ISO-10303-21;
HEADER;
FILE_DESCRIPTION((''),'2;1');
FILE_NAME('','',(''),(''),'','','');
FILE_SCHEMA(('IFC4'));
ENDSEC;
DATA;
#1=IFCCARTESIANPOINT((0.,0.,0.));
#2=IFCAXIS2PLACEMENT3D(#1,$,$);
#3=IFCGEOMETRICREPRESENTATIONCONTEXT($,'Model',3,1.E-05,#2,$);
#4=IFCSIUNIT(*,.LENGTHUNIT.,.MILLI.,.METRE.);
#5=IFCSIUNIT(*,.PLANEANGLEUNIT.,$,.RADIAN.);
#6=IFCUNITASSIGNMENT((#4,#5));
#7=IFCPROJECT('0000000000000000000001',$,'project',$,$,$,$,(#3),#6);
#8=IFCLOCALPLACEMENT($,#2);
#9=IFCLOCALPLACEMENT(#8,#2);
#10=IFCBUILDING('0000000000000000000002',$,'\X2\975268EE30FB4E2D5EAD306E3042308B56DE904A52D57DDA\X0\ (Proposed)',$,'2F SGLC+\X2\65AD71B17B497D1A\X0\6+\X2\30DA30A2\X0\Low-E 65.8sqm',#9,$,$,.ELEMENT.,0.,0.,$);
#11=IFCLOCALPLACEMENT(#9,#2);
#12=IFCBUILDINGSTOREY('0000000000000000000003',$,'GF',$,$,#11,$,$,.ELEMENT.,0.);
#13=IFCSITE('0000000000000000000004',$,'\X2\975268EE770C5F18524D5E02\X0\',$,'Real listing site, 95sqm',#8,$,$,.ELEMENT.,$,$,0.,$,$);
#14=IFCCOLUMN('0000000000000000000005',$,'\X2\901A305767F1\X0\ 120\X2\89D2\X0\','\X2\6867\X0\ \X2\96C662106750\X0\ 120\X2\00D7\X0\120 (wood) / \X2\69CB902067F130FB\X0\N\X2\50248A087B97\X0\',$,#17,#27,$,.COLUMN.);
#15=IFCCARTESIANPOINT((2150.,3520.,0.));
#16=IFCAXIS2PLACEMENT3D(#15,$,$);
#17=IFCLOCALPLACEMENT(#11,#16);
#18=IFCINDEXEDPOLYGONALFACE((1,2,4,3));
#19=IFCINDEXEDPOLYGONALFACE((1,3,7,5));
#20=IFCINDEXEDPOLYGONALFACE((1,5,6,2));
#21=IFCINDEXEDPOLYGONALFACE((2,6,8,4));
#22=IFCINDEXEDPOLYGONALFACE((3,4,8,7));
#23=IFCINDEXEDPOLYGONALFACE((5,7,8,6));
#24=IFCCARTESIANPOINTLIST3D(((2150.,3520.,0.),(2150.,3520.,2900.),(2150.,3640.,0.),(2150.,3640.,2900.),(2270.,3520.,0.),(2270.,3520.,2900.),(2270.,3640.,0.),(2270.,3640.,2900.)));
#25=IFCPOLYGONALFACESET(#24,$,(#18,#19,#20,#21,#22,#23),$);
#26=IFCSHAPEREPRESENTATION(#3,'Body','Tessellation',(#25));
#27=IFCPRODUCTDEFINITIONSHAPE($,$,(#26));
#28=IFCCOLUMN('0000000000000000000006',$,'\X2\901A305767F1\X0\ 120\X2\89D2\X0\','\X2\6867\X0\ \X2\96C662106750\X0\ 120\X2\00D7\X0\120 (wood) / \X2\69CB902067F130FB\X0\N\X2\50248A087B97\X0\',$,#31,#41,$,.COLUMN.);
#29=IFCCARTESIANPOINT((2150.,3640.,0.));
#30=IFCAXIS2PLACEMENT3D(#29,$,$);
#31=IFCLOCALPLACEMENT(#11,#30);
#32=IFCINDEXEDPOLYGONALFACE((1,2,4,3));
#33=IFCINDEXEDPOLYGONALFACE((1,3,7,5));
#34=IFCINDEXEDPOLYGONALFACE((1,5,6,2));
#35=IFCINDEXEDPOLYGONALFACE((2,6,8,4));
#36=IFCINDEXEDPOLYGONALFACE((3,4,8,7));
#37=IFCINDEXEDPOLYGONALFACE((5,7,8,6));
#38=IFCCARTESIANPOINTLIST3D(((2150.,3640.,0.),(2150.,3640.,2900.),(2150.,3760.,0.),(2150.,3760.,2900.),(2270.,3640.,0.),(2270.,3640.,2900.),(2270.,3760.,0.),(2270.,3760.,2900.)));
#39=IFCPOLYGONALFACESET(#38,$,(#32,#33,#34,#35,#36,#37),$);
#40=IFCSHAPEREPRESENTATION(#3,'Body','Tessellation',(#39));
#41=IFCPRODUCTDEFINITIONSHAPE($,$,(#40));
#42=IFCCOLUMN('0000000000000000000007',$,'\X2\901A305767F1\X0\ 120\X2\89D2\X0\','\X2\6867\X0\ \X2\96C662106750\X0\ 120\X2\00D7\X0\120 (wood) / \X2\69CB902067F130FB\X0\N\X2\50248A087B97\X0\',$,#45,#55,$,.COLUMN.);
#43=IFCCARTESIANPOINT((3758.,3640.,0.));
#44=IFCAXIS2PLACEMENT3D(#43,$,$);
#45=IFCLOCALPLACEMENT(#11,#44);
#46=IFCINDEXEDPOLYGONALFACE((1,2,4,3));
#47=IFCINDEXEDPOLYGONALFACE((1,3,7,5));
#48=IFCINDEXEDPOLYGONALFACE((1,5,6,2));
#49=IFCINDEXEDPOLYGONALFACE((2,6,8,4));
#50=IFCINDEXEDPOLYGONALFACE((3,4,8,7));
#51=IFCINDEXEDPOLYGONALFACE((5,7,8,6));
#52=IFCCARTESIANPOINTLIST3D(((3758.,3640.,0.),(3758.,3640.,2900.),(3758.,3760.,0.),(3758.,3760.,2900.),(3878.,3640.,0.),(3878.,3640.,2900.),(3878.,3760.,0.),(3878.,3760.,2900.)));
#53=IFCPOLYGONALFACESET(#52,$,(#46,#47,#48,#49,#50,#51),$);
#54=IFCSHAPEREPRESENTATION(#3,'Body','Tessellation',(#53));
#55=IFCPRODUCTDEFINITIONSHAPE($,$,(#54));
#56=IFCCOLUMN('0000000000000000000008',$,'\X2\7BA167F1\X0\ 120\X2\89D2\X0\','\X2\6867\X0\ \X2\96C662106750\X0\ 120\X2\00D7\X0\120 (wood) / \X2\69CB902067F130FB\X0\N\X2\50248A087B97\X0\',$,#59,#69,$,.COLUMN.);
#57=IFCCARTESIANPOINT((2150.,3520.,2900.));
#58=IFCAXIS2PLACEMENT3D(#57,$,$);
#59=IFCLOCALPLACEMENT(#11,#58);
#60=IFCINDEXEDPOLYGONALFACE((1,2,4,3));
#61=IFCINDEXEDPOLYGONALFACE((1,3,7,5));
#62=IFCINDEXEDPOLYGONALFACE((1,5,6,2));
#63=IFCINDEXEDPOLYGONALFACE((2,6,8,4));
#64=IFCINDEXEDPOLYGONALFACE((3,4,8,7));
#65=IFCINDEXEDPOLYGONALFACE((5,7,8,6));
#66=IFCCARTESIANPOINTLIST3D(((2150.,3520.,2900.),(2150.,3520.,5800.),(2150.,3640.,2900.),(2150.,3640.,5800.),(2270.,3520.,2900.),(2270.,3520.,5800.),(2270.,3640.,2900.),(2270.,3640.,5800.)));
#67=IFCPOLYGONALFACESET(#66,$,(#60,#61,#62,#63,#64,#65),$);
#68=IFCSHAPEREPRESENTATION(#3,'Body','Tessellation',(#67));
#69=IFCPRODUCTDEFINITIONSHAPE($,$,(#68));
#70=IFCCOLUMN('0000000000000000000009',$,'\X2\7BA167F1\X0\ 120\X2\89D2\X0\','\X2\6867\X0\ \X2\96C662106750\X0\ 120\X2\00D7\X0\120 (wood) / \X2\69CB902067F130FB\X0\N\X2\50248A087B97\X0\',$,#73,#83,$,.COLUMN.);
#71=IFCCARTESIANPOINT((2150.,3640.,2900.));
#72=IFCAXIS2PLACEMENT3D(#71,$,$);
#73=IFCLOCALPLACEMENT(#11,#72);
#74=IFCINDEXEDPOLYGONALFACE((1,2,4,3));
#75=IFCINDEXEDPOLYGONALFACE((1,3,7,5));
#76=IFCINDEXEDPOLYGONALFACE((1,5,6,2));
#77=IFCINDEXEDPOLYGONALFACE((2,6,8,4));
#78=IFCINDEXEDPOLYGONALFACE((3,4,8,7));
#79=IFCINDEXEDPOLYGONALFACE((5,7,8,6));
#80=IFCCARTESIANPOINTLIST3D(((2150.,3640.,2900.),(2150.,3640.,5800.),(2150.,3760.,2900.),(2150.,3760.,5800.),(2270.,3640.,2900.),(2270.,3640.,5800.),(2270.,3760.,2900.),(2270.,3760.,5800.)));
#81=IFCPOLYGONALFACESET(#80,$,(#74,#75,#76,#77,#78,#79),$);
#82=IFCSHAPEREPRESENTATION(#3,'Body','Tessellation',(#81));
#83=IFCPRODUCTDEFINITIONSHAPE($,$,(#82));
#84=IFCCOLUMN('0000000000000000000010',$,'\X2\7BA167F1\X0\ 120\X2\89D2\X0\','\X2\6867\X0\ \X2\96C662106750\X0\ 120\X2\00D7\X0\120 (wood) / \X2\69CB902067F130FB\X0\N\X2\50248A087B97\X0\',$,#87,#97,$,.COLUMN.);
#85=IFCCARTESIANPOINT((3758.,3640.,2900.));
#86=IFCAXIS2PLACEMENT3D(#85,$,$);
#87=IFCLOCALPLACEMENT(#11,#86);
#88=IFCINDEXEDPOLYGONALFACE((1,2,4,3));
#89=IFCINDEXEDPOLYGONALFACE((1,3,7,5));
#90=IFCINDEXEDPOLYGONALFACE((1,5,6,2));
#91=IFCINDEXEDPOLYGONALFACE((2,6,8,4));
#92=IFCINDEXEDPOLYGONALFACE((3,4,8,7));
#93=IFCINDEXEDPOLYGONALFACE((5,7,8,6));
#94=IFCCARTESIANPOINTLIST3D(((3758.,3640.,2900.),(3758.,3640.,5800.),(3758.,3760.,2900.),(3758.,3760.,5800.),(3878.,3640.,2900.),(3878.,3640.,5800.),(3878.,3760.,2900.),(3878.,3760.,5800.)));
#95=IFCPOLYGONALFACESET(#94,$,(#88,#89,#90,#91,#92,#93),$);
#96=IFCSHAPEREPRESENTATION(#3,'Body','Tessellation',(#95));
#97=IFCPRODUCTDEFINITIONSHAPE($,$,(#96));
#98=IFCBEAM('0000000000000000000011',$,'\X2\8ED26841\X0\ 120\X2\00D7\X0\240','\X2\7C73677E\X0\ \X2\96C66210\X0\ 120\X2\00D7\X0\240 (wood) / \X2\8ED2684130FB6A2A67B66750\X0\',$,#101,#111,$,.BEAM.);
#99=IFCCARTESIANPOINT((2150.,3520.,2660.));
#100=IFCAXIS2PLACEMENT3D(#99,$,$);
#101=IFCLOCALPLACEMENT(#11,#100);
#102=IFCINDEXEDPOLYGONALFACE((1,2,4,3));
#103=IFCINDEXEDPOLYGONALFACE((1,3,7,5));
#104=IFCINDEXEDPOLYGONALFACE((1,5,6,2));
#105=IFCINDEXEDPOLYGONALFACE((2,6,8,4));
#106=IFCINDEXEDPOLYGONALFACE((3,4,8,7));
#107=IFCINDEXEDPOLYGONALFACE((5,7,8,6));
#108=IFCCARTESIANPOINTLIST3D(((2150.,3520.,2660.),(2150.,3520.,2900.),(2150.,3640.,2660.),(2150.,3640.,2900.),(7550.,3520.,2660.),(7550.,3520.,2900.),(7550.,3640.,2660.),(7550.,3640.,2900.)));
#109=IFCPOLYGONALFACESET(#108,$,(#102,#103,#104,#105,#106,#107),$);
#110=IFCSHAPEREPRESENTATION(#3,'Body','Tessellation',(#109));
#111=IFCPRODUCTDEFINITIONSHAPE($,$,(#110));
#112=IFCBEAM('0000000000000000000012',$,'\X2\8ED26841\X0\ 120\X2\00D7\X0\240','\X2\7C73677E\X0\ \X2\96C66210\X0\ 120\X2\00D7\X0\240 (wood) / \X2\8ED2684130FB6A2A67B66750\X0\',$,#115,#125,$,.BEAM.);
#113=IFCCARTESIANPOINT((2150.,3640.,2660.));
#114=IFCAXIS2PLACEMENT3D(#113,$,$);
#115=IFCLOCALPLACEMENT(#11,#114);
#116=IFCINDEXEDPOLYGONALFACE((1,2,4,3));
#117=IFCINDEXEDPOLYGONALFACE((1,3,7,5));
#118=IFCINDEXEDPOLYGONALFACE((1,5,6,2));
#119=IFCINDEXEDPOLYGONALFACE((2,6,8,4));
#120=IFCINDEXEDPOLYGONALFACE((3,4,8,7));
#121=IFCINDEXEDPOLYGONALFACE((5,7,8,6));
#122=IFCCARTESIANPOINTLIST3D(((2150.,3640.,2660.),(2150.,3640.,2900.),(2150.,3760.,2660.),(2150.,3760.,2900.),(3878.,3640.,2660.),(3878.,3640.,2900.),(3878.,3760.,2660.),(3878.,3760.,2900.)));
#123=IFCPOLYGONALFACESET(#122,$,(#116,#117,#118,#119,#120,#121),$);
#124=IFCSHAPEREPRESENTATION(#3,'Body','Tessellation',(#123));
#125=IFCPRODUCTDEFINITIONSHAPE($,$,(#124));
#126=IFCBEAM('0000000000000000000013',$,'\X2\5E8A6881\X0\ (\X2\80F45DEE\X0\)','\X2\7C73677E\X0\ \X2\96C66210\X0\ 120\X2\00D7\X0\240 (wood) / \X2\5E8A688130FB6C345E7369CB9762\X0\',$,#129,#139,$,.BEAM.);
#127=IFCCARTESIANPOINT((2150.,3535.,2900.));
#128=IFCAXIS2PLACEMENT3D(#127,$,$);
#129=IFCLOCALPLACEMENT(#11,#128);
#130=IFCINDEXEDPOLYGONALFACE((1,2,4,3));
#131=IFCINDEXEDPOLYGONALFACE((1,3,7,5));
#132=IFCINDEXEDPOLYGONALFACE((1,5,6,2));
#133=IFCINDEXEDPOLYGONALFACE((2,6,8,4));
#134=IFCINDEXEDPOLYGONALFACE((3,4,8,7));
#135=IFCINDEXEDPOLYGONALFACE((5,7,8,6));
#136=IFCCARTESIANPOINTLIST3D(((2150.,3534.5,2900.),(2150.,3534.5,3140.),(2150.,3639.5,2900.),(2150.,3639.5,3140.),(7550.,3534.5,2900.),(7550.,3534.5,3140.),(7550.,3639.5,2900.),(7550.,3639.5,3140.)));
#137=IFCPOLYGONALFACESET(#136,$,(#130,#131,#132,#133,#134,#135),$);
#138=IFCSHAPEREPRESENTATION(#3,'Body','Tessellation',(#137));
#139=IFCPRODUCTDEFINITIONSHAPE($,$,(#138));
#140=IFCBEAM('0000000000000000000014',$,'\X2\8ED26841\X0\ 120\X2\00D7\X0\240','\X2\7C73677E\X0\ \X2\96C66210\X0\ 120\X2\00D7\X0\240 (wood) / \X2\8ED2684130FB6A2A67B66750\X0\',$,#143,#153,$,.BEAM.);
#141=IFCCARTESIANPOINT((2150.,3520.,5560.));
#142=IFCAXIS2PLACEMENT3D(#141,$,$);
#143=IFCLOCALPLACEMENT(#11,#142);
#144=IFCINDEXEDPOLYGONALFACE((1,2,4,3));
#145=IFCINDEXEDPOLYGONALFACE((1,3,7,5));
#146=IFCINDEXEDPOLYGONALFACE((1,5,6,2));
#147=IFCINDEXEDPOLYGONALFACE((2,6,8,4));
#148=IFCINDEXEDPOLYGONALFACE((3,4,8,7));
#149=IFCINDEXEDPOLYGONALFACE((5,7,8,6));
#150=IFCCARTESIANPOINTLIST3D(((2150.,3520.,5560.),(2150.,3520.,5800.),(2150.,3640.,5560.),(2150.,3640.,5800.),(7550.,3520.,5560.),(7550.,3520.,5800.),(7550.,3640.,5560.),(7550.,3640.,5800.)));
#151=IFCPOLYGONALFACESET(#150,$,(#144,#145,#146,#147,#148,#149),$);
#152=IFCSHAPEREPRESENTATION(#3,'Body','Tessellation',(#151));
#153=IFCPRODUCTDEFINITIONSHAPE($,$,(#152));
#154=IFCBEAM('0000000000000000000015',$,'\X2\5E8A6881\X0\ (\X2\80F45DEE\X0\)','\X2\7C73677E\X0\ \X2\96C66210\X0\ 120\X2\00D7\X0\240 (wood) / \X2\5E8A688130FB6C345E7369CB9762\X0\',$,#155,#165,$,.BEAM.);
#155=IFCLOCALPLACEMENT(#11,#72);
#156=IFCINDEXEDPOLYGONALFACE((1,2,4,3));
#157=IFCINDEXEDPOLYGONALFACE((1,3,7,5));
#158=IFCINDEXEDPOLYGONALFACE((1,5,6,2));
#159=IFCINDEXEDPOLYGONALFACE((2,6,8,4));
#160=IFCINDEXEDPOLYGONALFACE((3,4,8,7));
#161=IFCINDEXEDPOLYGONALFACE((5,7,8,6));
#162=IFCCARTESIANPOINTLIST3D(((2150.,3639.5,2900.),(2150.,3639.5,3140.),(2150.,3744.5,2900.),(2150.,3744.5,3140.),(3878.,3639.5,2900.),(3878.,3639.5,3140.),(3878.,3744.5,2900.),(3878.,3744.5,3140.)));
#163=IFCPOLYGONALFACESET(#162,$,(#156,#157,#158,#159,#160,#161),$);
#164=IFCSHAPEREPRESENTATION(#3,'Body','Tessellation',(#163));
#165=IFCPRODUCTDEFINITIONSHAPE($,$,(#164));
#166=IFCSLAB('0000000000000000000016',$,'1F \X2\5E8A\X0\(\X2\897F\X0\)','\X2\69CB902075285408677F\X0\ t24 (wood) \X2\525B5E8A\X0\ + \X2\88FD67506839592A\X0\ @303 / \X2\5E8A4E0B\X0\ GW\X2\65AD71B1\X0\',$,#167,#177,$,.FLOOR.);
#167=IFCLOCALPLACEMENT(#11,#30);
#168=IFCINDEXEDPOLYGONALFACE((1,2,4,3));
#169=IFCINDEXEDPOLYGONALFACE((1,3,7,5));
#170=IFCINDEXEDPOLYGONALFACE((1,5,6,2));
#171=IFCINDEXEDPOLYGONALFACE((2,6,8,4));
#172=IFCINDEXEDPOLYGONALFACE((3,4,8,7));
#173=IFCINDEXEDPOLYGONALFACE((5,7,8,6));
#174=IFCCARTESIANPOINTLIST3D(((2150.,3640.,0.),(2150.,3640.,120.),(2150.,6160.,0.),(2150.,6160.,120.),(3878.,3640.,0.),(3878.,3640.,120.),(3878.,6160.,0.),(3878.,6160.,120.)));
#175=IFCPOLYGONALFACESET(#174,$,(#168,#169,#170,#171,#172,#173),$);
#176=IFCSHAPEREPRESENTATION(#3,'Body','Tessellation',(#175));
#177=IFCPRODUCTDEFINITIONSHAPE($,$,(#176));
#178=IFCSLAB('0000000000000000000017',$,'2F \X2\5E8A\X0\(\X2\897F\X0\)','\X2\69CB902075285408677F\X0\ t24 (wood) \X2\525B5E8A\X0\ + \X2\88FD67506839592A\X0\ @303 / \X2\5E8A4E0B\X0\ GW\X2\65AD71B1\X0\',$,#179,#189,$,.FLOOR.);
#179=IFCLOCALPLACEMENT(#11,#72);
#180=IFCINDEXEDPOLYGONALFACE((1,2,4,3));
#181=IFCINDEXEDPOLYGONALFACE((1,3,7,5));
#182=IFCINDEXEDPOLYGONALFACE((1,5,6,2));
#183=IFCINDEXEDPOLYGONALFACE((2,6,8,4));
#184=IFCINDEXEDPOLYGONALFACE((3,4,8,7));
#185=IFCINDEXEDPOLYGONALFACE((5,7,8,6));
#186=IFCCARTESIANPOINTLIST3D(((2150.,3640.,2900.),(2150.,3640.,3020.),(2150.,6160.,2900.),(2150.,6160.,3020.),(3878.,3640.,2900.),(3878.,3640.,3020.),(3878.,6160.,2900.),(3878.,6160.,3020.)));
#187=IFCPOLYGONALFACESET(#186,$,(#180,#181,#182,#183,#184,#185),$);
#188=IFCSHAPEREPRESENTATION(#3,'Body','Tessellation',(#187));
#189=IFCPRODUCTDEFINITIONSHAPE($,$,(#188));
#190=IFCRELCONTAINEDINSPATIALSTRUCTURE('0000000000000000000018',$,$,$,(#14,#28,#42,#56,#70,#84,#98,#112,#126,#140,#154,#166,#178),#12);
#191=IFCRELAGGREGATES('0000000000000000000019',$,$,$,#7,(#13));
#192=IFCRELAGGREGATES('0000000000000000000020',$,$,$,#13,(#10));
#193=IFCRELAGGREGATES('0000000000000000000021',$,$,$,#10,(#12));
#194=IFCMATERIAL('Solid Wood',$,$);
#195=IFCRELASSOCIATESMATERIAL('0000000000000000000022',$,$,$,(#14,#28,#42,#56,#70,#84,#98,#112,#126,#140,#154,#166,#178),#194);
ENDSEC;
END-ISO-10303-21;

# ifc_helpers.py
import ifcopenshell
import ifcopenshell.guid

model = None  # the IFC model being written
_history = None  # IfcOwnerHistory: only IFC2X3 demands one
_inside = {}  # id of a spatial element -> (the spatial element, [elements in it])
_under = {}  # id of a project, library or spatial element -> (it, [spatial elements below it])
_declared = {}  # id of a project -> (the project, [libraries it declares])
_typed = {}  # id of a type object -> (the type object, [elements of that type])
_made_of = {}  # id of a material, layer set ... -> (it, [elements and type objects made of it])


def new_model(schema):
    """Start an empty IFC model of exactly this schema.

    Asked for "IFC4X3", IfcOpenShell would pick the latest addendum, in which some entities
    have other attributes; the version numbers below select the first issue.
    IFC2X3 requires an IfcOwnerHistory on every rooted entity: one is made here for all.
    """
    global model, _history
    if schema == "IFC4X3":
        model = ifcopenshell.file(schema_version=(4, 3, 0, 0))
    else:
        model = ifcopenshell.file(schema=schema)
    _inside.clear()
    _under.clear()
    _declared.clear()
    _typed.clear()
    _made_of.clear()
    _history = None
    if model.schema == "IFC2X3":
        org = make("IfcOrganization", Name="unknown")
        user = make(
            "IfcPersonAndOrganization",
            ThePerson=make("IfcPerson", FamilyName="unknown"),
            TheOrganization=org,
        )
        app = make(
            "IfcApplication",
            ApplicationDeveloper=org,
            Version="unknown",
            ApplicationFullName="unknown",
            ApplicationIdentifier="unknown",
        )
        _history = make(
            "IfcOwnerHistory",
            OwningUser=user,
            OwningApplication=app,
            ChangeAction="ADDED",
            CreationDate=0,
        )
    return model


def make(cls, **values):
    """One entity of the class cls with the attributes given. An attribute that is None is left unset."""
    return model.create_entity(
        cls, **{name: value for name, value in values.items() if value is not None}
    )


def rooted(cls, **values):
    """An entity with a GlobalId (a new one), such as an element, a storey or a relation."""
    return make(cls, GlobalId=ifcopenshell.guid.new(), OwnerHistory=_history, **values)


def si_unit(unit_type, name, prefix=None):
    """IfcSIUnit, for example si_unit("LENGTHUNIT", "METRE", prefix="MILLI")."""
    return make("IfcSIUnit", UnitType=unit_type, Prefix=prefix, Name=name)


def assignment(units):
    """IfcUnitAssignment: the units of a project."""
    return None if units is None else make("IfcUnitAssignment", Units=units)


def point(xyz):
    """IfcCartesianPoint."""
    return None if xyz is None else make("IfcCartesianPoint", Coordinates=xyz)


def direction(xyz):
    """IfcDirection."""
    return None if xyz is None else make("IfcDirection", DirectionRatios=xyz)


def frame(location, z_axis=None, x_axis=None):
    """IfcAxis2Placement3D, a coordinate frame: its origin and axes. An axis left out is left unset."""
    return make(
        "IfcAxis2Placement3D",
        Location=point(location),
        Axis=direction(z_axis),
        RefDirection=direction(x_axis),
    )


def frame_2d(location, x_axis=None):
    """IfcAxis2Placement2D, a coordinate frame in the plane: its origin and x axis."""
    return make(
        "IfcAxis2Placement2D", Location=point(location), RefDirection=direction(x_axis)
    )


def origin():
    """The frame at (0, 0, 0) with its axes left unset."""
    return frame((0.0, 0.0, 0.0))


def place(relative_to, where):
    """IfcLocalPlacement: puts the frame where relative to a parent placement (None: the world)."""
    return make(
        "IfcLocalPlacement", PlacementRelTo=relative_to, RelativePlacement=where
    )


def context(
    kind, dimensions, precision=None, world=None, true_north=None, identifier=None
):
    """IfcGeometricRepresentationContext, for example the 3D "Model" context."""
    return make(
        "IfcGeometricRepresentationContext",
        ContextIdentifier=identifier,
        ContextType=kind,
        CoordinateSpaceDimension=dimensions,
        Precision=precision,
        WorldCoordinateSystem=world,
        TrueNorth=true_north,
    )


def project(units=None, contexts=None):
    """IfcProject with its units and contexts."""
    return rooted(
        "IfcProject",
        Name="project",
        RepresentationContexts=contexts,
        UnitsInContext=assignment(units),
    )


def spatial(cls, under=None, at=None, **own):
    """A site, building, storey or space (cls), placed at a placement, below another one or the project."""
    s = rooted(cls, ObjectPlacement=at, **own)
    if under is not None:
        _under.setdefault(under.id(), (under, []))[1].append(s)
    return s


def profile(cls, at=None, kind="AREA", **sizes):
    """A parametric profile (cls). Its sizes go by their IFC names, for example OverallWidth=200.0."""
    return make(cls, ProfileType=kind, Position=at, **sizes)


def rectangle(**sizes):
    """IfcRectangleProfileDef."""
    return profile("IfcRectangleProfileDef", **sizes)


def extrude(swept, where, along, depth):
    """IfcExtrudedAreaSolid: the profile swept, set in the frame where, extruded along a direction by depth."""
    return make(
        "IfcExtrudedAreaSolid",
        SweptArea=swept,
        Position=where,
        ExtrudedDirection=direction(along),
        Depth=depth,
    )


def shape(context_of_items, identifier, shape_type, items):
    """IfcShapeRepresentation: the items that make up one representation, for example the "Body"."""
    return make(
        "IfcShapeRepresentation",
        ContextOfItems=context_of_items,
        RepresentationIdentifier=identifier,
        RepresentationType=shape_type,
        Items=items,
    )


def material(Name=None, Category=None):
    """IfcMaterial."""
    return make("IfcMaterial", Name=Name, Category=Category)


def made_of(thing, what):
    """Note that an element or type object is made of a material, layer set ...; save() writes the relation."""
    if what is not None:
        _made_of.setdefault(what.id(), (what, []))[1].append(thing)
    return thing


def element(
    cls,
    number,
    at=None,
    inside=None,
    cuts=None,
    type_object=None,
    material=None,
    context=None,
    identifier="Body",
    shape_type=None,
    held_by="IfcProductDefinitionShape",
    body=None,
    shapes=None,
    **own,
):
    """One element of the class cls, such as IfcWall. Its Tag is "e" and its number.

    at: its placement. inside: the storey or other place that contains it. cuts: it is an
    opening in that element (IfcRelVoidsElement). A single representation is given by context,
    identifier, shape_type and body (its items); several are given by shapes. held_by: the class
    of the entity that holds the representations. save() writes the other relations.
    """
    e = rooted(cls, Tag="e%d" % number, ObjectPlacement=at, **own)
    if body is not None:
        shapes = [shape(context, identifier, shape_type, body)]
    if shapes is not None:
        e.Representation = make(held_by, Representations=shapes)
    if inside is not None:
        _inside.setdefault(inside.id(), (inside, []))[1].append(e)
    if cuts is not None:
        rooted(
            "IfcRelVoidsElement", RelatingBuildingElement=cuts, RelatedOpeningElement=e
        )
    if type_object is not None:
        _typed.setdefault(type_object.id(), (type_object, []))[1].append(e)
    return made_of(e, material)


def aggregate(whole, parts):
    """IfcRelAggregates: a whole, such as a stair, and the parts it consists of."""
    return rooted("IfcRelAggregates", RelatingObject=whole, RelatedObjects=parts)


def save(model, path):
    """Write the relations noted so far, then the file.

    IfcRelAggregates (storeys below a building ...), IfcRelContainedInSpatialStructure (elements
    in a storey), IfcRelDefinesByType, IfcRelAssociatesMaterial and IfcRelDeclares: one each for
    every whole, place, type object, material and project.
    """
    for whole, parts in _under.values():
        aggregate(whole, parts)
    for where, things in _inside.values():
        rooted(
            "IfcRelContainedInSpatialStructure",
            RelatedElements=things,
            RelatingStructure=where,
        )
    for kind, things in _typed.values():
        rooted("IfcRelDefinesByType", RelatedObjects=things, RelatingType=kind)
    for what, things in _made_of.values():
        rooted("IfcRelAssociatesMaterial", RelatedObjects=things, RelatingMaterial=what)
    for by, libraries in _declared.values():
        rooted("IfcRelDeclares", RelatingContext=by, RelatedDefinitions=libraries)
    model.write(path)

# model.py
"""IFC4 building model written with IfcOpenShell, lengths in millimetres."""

from ifc_helpers import new_model, si_unit, frame, frame_2d, origin, place, context, project, spatial, rectangle, extrude, material, element, save


model = new_model("IFC4")

# Units and contexts
model_context = context("Model", 3, precision=1e-05, world=origin())
ifc_project = project(units=[si_unit("LENGTHUNIT", "METRE", prefix="MILLI"), si_unit("PLANEANGLEUNIT", "RADIAN")], contexts=[model_context])

# Site, building, storey
site_placement = place(None, origin())
site = spatial("IfcSite", under=ifc_project, at=site_placement, Name="青森県弘前市", ObjectType="Real listing site, 95sqm", CompositionType="ELEMENT", RefElevation=0.0)
building_placement = place(site_placement, origin())
building = spatial("IfcBuilding", under=site, at=building_placement, Name="青森・中庭のある回遊動線 (Proposed)", ObjectType="2F SGLC+断熱等級6+ペアLow-E 65.8sqm", CompositionType="ELEMENT", ElevationOfRefHeight=0.0, ElevationOfTerrain=0.0)
storey_placement = place(building_placement, origin())
storey = spatial("IfcBuildingStorey", under=building, at=storey_placement, Name="GF", CompositionType="ELEMENT", Elevation=0.0)

# Columns
ifc_material_1 = material(Name="Solid Wood")
column_1_placement = place(storey_placement, frame((2150.0, 3520.0, 0.0)))
element("IfcColumn", 1, at=column_1_placement, inside=storey, material=ifc_material_1, Name="通し柱 120角", Description="桧 集成材 120×120 (wood) / 構造柱・N値計算", PredefinedType="COLUMN", context=model_context, shape_type="SweptSolid", body=[
    extrude(rectangle(XDim=120.0, YDim=120.0, at=frame_2d((60.0, 60.0))), frame((2150.0, 3520.0, 0.0)), (0.0, 0.0, 1.0), 2900.0),
])
column_2_placement = place(storey_placement, frame((2150.0, 3640.0, 0.0)))
element("IfcColumn", 2, at=column_2_placement, inside=storey, material=ifc_material_1, Name="通し柱 120角", Description="桧 集成材 120×120 (wood) / 構造柱・N値計算", PredefinedType="COLUMN", context=model_context, shape_type="SweptSolid", body=[
    extrude(rectangle(XDim=120.0, YDim=120.0, at=frame_2d((60.0, 60.0))), frame((2150.0, 3640.0, 0.0)), (0.0, 0.0, 1.0), 2900.0),
])
column_3_placement = place(storey_placement, frame((3758.0, 3640.0, 0.0)))
element("IfcColumn", 3, at=column_3_placement, inside=storey, material=ifc_material_1, Name="通し柱 120角", Description="桧 集成材 120×120 (wood) / 構造柱・N値計算", PredefinedType="COLUMN", context=model_context, shape_type="SweptSolid", body=[
    extrude(rectangle(XDim=120.0, YDim=120.0, at=frame_2d((60.0, 60.0))), frame((3758.0, 3640.0, 0.0)), (0.0, 0.0, 1.0), 2900.0),
])
column_4_placement = place(storey_placement, frame((2150.0, 3520.0, 2900.0)))
element("IfcColumn", 4, at=column_4_placement, inside=storey, material=ifc_material_1, Name="管柱 120角", Description="桧 集成材 120×120 (wood) / 構造柱・N値計算", PredefinedType="COLUMN", context=model_context, shape_type="SweptSolid", body=[
    extrude(rectangle(XDim=120.0, YDim=120.0, at=frame_2d((60.0, 60.0))), frame((2150.0, 3520.0, 2900.0)), (0.0, 0.0, 1.0), 2900.0),
])
column_5_placement = place(storey_placement, frame((2150.0, 3640.0, 2900.0)))
element("IfcColumn", 5, at=column_5_placement, inside=storey, material=ifc_material_1, Name="管柱 120角", Description="桧 集成材 120×120 (wood) / 構造柱・N値計算", PredefinedType="COLUMN", context=model_context, shape_type="SweptSolid", body=[
    extrude(rectangle(XDim=120.0, YDim=120.0, at=frame_2d((60.0, 60.0))), frame((2150.0, 3640.0, 2900.0)), (0.0, 0.0, 1.0), 2900.0),
])
column_6_placement = place(storey_placement, frame((3758.0, 3640.0, 2900.0)))
element("IfcColumn", 6, at=column_6_placement, inside=storey, material=ifc_material_1, Name="管柱 120角", Description="桧 集成材 120×120 (wood) / 構造柱・N値計算", PredefinedType="COLUMN", context=model_context, shape_type="SweptSolid", body=[
    extrude(rectangle(XDim=120.0, YDim=120.0, at=frame_2d((60.0, 60.0))), frame((3758.0, 3640.0, 2900.0)), (0.0, 0.0, 1.0), 2900.0),
])

# Beams
beam_1_placement = place(storey_placement, frame((2150.0, 3520.0, 2660.0)))
element("IfcBeam", 7, at=beam_1_placement, inside=storey, material=ifc_material_1, Name="軒桁 120×240", Description="米松 集成 120×240 (wood) / 軒桁・横架材", PredefinedType="BEAM", context=model_context, shape_type="SweptSolid", body=[
    extrude(rectangle(XDim=5400.0, YDim=120.0, at=frame_2d((2700.0, 60.0))), frame((2150.0, 3520.0, 2660.0)), (0.0, 0.0, 1.0), 240.0),
])
beam_2_placement = place(storey_placement, frame((2150.0, 3640.0, 2660.0)))
element("IfcBeam", 8, at=beam_2_placement, inside=storey, material=ifc_material_1, Name="軒桁 120×240", Description="米松 集成 120×240 (wood) / 軒桁・横架材", PredefinedType="BEAM", context=model_context, shape_type="SweptSolid", body=[
    extrude(rectangle(XDim=1728.0, YDim=120.0, at=frame_2d((864.0, 60.0))), frame((2150.0, 3640.0, 2660.0)), (0.0, 0.0, 1.0), 240.0),
])
beam_3_placement = place(storey_placement, frame((2150.0, 3535.0, 2900.0)))
element("IfcBeam", 9, at=beam_3_placement, inside=storey, material=ifc_material_1, Name="床梁 (胴差)", Description="米松 集成 120×240 (wood) / 床梁・水平構面", PredefinedType="BEAM", context=model_context, shape_type="SweptSolid", body=[
    extrude(rectangle(XDim=5400.0, YDim=105.0, at=frame_2d((2700.0, 52.0))), frame((2150.0, 3535.0, 2900.0)), (0.0, 0.0, 1.0), 240.0),
])
beam_4_placement = place(storey_placement, frame((2150.0, 3520.0, 5560.0)))
element("IfcBeam", 10, at=beam_4_placement, inside=storey, material=ifc_material_1, Name="軒桁 120×240", Description="米松 集成 120×240 (wood) / 軒桁・横架材", PredefinedType="BEAM", context=model_context, shape_type="SweptSolid", body=[
    extrude(rectangle(XDim=5400.0, YDim=120.0, at=frame_2d((2700.0, 60.0))), frame((2150.0, 3520.0, 5560.0)), (0.0, 0.0, 1.0), 240.0),
])
beam_5_placement = place(storey_placement, frame((2150.0, 3640.0, 2900.0)))
element("IfcBeam", 11, at=beam_5_placement, inside=storey, material=ifc_material_1, Name="床梁 (胴差)", Description="米松 集成 120×240 (wood) / 床梁・水平構面", PredefinedType="BEAM", context=model_context, shape_type="SweptSolid", body=[
    extrude(rectangle(XDim=1728.0, YDim=105.0, at=frame_2d((864.0, 52.0))), frame((2150.0, 3640.0, 2900.0)), (0.0, 0.0, 1.0), 240.0),
])

# Slabs
slab_1_placement = place(storey_placement, frame((2150.0, 3640.0, 0.0)))
element("IfcSlab", 12, at=slab_1_placement, inside=storey, material=ifc_material_1, Name="1F 床(西)", Description="構造用合板 t24 (wood) 剛床 + 製材根太 @303 / 床下 GW断熱", PredefinedType="FLOOR", context=model_context, shape_type="SweptSolid", body=[
    extrude(rectangle(XDim=1728.0, YDim=2520.0, at=frame_2d((864.0, 1260.0))), frame((2150.0, 3640.0, 0.0)), (0.0, 0.0, 1.0), 120.0),
])
slab_2_placement = place(storey_placement, frame((2150.0, 3640.0, 2900.0)))
element("IfcSlab", 13, at=slab_2_placement, inside=storey, material=ifc_material_1, Name="2F 床(西)", Description="構造用合板 t24 (wood) 剛床 + 製材根太 @303 / 床下 GW断熱", PredefinedType="FLOOR", context=model_context, shape_type="SweptSolid", body=[
    extrude(rectangle(XDim=1728.0, YDim=2520.0, at=frame_2d((864.0, 1260.0))), frame((2150.0, 3640.0, 2900.0)), (0.0, 0.0, 1.0), 120.0),
])

save(model, "model.ifc")
